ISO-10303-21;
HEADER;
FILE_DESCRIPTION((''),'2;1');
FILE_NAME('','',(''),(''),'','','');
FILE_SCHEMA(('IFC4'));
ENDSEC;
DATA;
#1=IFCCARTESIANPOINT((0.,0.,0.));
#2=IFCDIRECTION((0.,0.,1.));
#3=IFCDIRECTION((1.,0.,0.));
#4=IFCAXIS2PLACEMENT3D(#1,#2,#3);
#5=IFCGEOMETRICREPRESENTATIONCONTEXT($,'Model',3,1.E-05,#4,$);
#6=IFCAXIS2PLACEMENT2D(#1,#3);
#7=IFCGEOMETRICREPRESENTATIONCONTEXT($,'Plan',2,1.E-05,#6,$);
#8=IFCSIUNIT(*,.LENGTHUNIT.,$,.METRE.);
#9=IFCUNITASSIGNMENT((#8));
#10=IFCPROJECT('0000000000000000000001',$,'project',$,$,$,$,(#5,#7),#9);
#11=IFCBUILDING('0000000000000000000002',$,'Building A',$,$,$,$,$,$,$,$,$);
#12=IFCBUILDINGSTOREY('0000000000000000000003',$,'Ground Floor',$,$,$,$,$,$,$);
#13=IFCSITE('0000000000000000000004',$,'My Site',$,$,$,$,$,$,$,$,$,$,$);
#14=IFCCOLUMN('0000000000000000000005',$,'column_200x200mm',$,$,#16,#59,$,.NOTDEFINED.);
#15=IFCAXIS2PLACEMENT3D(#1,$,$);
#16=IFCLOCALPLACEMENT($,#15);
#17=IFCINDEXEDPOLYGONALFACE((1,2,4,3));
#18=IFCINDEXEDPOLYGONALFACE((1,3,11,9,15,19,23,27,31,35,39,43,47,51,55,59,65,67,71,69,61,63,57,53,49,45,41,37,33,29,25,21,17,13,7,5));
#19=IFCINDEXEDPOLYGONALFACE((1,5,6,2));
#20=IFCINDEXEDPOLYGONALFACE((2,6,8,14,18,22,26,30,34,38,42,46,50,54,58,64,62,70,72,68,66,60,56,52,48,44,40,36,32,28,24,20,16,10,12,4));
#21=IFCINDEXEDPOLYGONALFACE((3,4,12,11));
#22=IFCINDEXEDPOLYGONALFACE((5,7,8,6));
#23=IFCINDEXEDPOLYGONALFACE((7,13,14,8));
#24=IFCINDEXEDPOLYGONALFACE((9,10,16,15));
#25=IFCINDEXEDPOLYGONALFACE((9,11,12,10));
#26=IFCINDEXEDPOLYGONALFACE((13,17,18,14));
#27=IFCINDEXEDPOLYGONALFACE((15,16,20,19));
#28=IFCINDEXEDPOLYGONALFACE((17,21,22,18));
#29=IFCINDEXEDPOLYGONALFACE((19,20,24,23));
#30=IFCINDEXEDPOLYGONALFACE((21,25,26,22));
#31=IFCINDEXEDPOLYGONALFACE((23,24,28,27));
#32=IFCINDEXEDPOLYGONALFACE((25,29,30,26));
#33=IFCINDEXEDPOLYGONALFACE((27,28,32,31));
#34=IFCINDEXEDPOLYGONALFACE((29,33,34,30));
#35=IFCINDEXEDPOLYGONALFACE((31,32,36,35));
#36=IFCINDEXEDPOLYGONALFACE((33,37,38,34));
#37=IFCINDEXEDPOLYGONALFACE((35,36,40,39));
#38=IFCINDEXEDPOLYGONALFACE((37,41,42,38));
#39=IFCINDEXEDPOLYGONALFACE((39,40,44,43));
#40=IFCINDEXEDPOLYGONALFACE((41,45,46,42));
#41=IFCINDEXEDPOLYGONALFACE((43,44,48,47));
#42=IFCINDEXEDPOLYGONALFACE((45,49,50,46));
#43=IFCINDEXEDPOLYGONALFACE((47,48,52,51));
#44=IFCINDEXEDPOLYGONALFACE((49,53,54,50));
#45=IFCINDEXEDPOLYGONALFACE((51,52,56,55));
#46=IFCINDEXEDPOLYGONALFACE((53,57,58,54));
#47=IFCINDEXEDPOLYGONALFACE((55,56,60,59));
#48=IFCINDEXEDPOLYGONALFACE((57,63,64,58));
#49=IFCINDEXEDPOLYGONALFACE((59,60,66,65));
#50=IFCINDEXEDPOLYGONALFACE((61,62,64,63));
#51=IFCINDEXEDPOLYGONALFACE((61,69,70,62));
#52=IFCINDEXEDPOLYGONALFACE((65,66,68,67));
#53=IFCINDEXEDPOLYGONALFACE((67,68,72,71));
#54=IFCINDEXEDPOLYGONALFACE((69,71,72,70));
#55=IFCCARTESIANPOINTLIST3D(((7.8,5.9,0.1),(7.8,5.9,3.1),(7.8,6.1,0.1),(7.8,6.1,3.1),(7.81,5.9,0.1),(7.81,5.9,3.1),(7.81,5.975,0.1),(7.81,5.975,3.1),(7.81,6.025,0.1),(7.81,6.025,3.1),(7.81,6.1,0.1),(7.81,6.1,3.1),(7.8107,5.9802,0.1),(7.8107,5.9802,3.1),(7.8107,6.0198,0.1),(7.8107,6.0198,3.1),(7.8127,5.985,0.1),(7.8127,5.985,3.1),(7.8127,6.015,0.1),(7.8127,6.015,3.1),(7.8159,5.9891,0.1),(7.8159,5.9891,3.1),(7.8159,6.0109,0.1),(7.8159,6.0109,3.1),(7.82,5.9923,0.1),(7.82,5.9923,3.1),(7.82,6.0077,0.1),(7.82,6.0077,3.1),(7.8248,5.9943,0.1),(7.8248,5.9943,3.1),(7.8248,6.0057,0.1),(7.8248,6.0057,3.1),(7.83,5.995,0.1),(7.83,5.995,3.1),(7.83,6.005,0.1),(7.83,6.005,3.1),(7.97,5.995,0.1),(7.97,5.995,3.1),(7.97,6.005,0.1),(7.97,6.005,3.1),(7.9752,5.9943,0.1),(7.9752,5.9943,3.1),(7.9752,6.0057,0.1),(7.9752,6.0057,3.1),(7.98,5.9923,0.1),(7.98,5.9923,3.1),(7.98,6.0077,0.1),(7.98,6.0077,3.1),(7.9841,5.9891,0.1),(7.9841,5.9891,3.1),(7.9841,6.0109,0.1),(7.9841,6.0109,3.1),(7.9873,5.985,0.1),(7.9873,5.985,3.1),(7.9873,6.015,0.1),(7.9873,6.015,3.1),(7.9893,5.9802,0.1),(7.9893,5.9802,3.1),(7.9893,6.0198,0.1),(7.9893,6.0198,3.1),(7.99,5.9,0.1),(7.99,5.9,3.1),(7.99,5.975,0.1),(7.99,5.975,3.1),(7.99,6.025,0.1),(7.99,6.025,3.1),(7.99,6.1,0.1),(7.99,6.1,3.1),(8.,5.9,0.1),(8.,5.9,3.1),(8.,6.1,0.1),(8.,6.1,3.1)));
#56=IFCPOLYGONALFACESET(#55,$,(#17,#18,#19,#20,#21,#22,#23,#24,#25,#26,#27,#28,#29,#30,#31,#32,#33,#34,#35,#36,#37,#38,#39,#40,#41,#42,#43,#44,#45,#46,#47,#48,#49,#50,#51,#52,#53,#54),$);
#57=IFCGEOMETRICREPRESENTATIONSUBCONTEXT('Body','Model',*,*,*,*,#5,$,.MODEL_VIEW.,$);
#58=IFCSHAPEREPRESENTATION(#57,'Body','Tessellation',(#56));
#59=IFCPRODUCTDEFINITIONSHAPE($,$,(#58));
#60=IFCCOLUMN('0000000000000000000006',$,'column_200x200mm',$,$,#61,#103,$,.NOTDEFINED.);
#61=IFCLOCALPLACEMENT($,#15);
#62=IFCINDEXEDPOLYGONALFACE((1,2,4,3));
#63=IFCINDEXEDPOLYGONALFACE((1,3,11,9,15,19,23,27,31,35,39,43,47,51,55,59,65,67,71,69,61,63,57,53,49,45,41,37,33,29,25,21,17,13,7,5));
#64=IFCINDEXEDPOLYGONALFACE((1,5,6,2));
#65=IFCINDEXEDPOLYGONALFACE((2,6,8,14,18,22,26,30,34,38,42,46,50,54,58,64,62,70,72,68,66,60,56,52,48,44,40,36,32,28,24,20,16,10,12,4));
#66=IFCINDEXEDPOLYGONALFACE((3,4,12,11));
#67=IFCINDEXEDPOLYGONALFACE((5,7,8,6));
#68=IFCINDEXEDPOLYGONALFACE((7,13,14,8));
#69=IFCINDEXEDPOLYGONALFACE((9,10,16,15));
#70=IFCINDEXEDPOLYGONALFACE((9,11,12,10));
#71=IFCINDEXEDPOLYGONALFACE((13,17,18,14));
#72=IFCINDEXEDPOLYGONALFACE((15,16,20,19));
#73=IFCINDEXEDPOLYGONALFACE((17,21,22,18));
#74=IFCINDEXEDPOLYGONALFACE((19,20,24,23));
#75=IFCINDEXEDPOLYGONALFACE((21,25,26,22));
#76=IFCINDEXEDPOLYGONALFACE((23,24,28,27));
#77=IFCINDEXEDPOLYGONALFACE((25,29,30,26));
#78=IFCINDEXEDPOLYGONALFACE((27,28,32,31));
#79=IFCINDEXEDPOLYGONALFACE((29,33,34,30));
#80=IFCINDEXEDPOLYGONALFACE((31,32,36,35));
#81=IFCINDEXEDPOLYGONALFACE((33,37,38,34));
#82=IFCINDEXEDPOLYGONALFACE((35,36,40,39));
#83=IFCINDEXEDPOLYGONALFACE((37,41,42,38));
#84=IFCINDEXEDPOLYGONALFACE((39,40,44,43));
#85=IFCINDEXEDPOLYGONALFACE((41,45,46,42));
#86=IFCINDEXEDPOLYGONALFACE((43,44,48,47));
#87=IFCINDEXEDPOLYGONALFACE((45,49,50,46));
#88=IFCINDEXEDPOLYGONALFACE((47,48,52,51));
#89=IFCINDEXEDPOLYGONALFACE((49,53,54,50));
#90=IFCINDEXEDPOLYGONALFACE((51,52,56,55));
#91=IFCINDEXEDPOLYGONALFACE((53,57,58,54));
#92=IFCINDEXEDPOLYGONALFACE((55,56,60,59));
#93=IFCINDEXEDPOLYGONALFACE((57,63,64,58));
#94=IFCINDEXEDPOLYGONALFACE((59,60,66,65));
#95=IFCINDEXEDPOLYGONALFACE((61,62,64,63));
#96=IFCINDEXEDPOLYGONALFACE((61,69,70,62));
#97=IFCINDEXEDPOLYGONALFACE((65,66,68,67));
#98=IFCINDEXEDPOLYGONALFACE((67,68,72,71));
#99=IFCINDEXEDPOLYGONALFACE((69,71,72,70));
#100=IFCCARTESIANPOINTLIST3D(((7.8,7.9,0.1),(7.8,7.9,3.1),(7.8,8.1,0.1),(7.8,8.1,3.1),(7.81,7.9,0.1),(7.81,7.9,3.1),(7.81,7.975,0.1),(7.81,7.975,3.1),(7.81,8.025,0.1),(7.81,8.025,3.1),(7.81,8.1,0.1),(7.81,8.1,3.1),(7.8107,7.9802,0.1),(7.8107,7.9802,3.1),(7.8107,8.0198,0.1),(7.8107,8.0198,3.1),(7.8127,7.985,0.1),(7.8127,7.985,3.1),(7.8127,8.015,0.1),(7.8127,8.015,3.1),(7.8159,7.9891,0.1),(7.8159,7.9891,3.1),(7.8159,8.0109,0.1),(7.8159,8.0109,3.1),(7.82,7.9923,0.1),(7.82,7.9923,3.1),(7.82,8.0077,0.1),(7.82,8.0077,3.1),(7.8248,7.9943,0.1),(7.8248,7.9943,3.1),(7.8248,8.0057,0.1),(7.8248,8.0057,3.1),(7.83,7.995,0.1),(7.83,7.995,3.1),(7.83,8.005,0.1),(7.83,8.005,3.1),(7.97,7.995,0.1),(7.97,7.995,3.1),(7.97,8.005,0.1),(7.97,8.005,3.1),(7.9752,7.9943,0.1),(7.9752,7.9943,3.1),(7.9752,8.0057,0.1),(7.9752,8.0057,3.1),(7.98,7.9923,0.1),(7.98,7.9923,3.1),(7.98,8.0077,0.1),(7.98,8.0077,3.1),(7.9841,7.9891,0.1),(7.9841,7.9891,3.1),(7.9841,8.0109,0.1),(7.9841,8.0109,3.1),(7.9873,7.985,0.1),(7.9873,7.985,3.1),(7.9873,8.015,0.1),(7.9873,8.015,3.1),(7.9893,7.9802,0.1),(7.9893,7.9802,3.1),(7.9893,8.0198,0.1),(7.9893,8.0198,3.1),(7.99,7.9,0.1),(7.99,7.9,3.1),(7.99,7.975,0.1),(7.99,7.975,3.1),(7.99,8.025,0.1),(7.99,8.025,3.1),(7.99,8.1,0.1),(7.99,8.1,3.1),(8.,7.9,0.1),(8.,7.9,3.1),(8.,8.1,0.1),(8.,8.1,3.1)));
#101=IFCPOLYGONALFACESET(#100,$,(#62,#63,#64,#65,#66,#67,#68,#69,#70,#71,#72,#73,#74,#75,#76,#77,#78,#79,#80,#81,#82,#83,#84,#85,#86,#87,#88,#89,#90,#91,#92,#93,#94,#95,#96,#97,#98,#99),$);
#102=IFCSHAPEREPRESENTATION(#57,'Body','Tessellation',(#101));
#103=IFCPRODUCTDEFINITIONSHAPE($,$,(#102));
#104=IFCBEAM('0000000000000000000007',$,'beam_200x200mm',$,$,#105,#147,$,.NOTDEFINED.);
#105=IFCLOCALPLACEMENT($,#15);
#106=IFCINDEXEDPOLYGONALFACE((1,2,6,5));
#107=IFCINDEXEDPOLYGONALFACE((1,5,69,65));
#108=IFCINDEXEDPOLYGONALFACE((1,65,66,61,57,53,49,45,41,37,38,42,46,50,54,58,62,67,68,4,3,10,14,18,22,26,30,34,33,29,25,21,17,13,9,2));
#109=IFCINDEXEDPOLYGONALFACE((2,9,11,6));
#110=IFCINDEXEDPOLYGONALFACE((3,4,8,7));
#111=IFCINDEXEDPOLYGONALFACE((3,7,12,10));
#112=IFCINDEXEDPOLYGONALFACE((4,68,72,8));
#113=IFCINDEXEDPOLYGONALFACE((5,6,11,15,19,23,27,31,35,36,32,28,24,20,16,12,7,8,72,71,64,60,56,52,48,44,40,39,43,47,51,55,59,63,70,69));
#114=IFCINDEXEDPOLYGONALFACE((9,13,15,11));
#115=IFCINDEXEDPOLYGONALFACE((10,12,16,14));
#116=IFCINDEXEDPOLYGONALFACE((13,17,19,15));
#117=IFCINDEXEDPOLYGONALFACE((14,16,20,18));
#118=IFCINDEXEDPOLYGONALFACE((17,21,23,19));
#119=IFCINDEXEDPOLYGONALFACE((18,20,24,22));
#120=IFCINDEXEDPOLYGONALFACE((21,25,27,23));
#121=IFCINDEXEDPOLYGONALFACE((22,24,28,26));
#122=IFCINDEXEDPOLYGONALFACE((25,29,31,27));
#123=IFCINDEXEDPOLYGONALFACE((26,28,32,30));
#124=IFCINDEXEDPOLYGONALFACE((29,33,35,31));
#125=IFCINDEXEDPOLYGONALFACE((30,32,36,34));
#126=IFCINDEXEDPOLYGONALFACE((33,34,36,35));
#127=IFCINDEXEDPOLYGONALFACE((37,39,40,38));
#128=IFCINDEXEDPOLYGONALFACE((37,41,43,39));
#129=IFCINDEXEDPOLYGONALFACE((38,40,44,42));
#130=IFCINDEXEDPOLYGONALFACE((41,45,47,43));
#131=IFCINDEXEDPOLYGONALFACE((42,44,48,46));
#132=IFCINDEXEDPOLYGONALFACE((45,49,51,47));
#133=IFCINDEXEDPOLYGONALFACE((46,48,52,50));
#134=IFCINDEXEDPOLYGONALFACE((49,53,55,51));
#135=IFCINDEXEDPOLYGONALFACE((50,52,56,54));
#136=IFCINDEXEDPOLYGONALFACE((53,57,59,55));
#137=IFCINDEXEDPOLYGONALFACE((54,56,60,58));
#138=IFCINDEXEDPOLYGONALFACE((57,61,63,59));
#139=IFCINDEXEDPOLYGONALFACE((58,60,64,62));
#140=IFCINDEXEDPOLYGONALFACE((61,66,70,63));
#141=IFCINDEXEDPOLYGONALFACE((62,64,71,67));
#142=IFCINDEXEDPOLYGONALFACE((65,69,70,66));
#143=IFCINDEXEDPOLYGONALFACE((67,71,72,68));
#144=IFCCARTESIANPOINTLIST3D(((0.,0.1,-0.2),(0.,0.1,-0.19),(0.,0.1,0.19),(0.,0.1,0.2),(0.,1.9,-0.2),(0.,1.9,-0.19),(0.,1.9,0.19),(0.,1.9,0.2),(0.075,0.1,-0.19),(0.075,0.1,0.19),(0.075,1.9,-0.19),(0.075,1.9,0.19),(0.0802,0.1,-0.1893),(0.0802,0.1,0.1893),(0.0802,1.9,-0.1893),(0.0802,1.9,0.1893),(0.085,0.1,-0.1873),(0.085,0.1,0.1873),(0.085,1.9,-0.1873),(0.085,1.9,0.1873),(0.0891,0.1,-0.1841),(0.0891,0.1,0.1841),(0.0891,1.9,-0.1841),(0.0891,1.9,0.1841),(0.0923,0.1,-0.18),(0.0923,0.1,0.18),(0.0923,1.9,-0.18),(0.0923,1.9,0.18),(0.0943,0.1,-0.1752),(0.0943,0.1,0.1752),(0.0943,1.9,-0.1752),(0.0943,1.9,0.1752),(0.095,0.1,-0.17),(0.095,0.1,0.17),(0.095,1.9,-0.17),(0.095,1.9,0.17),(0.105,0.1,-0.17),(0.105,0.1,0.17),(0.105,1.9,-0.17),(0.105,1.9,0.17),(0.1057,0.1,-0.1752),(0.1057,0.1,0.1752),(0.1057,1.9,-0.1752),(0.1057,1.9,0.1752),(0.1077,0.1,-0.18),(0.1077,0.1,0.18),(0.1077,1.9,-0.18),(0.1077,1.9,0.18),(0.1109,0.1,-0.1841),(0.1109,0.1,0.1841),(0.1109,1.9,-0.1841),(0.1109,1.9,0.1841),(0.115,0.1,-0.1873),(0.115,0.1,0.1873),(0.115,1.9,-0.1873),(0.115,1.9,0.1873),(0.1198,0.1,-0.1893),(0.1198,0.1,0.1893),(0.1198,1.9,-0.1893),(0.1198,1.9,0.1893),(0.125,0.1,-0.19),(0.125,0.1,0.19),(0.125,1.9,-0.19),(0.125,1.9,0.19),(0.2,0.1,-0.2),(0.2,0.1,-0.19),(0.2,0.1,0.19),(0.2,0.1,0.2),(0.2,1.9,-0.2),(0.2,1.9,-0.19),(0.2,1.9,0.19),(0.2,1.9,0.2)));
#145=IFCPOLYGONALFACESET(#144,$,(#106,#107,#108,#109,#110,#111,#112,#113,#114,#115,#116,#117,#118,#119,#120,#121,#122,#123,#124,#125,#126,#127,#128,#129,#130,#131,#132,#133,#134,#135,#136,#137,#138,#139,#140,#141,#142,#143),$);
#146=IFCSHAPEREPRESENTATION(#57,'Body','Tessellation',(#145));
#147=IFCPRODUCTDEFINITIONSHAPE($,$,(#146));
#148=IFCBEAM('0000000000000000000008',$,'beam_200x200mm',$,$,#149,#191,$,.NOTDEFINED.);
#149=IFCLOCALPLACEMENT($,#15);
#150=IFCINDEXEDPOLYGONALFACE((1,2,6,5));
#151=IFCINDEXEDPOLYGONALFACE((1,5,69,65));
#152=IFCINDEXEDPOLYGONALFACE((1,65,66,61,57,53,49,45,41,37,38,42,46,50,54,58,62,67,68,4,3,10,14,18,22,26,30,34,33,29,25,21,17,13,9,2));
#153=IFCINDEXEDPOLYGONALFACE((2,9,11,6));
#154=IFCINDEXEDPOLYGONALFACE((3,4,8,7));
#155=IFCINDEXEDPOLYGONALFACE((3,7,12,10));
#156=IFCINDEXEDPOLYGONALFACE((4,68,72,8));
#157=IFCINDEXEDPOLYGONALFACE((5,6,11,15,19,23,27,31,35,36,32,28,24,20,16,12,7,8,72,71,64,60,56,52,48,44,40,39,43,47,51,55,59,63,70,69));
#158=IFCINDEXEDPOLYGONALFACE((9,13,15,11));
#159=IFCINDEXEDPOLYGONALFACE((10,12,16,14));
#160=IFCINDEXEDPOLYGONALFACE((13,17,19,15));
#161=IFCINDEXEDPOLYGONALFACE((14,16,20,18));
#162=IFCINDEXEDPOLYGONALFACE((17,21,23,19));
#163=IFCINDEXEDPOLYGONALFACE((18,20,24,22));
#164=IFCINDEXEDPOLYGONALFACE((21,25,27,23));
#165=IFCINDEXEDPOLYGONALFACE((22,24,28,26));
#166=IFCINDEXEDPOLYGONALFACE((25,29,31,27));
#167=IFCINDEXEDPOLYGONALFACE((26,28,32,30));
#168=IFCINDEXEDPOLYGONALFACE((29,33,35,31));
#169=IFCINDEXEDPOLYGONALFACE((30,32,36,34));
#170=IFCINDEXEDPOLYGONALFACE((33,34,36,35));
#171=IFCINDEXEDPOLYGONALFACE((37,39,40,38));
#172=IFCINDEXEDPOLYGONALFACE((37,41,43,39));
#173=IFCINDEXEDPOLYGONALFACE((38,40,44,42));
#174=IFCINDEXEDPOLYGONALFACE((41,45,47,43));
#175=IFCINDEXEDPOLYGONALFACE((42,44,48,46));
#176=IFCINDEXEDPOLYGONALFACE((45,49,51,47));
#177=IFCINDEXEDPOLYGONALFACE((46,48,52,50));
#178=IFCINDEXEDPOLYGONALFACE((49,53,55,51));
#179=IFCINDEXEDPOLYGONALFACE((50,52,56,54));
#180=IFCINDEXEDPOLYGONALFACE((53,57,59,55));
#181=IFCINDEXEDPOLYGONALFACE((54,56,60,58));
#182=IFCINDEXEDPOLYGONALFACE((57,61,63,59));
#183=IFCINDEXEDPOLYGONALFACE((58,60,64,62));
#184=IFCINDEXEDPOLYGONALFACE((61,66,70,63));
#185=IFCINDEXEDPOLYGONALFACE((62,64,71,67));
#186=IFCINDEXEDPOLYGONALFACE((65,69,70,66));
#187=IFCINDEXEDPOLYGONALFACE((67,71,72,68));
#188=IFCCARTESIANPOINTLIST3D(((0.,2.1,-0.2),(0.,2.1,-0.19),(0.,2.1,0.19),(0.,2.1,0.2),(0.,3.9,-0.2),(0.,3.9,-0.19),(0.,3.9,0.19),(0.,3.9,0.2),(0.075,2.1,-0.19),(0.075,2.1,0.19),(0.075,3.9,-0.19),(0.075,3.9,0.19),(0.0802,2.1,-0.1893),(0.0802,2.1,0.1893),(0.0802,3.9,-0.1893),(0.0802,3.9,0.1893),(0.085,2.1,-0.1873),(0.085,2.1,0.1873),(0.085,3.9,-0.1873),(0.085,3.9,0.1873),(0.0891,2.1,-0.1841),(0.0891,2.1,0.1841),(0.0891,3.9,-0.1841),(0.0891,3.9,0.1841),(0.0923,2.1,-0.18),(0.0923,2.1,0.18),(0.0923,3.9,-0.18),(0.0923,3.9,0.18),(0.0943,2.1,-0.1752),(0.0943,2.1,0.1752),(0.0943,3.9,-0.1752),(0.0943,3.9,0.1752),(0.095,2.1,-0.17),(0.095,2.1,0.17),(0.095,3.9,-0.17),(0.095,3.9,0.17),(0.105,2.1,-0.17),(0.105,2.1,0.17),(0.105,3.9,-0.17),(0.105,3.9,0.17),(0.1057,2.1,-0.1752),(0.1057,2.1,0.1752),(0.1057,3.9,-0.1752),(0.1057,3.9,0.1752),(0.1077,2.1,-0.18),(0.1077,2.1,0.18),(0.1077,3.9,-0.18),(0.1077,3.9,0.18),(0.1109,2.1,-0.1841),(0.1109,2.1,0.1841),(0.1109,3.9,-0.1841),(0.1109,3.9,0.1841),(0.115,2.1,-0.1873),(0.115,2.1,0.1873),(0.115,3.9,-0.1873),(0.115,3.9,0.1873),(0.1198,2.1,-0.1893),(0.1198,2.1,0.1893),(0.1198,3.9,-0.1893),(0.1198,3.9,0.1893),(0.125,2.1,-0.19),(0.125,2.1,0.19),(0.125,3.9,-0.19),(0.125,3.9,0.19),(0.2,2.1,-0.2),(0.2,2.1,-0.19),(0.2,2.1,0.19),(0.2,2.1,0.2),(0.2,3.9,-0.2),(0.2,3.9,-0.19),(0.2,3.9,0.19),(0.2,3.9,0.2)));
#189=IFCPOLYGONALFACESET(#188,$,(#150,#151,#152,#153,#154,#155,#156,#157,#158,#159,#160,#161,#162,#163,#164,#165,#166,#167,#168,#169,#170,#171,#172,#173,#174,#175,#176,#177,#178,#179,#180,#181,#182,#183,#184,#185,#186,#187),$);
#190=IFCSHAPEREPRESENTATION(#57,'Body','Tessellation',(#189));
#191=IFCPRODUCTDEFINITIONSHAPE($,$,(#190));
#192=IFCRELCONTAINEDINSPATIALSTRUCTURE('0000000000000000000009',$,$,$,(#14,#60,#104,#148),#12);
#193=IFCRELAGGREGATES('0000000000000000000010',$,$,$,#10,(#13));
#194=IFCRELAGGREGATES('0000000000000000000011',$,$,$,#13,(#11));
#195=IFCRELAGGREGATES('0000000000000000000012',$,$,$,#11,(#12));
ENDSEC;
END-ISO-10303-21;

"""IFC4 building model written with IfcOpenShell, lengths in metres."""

from ifc_helpers import new_model, entity, si_unit, frame, frame_2d, origin_with_axes, place, context, subcontext, project, spatial, extrude, element, save


model = new_model("IFC4")

# Units and contexts
model_context = context("Model", 3, precision=1e-05, world=origin_with_axes())
plan_context = context("Plan", 2, precision=1e-05, world=frame_2d((0.0, 0.0, 0.0), x_axis=(1.0, 0.0, 0.0)))
body_context = subcontext(model_context, "Body", "Model", "MODEL_VIEW")
ifc_project = project(units=[si_unit("LENGTHUNIT", "METRE")], contexts=[model_context, plan_context])

# Site, building, storey
site = spatial("IfcSite", under=ifc_project, Name="My Site")
building = spatial("IfcBuilding", under=site, Name="Building A")
storey = spatial("IfcBuildingStorey", under=building, Name="Ground Floor")

# Columns
for number, where, z_axis, x_axis, name in (
    (1, (7.9, 6.0, 0.1), (0.0, 0.0, 1.0), (0.0, 1.0, 0.0), "column_200x200mm"),
    (2, (7.9, 8.0, 0.1), (0.0, 0.0, 1.0), (0.0, 1.0, 0.0), "column_200x200mm"),
):
    element("IfcColumn", number, at=place(None, frame(where, z_axis=z_axis, x_axis=x_axis)), inside=storey, Name=name, PredefinedType="NOTDEFINED", context=body_context, shape_type="SweptSolid", body=[
        extrude(entity("IfcIShapeProfileDef", None, None, None, 0.2, 0.2, 0.01, 0.01, 0.02), origin_with_axes(), (0.0, 0.0, 1.0), 3.0),
    ])

# Beams
for number, where, z_axis, x_axis, name in (
    (3, (0.1, 0.1, 0.0), (0.0, 1.0, 0.0), (1.0, 1.0, 0.0), "beam_200x200mm"),
    (4, (0.1, 2.1, 0.0), (0.0, 1.0, 0.0), (1.0, 1.0, 0.0), "beam_200x200mm"),
):
    element("IfcBeam", number, at=place(None, frame(where, z_axis=z_axis, x_axis=x_axis)), inside=storey, Name=name, PredefinedType="NOTDEFINED", context=body_context, shape_type="SweptSolid", body=[
        extrude(entity("IfcIShapeProfileDef", None, None, None, 0.2, 0.4, 0.01, 0.01, 0.02), origin_with_axes(), (0.0, 0.0, 1.0), 1.8),
    ])

save(model, "model.ifc")
